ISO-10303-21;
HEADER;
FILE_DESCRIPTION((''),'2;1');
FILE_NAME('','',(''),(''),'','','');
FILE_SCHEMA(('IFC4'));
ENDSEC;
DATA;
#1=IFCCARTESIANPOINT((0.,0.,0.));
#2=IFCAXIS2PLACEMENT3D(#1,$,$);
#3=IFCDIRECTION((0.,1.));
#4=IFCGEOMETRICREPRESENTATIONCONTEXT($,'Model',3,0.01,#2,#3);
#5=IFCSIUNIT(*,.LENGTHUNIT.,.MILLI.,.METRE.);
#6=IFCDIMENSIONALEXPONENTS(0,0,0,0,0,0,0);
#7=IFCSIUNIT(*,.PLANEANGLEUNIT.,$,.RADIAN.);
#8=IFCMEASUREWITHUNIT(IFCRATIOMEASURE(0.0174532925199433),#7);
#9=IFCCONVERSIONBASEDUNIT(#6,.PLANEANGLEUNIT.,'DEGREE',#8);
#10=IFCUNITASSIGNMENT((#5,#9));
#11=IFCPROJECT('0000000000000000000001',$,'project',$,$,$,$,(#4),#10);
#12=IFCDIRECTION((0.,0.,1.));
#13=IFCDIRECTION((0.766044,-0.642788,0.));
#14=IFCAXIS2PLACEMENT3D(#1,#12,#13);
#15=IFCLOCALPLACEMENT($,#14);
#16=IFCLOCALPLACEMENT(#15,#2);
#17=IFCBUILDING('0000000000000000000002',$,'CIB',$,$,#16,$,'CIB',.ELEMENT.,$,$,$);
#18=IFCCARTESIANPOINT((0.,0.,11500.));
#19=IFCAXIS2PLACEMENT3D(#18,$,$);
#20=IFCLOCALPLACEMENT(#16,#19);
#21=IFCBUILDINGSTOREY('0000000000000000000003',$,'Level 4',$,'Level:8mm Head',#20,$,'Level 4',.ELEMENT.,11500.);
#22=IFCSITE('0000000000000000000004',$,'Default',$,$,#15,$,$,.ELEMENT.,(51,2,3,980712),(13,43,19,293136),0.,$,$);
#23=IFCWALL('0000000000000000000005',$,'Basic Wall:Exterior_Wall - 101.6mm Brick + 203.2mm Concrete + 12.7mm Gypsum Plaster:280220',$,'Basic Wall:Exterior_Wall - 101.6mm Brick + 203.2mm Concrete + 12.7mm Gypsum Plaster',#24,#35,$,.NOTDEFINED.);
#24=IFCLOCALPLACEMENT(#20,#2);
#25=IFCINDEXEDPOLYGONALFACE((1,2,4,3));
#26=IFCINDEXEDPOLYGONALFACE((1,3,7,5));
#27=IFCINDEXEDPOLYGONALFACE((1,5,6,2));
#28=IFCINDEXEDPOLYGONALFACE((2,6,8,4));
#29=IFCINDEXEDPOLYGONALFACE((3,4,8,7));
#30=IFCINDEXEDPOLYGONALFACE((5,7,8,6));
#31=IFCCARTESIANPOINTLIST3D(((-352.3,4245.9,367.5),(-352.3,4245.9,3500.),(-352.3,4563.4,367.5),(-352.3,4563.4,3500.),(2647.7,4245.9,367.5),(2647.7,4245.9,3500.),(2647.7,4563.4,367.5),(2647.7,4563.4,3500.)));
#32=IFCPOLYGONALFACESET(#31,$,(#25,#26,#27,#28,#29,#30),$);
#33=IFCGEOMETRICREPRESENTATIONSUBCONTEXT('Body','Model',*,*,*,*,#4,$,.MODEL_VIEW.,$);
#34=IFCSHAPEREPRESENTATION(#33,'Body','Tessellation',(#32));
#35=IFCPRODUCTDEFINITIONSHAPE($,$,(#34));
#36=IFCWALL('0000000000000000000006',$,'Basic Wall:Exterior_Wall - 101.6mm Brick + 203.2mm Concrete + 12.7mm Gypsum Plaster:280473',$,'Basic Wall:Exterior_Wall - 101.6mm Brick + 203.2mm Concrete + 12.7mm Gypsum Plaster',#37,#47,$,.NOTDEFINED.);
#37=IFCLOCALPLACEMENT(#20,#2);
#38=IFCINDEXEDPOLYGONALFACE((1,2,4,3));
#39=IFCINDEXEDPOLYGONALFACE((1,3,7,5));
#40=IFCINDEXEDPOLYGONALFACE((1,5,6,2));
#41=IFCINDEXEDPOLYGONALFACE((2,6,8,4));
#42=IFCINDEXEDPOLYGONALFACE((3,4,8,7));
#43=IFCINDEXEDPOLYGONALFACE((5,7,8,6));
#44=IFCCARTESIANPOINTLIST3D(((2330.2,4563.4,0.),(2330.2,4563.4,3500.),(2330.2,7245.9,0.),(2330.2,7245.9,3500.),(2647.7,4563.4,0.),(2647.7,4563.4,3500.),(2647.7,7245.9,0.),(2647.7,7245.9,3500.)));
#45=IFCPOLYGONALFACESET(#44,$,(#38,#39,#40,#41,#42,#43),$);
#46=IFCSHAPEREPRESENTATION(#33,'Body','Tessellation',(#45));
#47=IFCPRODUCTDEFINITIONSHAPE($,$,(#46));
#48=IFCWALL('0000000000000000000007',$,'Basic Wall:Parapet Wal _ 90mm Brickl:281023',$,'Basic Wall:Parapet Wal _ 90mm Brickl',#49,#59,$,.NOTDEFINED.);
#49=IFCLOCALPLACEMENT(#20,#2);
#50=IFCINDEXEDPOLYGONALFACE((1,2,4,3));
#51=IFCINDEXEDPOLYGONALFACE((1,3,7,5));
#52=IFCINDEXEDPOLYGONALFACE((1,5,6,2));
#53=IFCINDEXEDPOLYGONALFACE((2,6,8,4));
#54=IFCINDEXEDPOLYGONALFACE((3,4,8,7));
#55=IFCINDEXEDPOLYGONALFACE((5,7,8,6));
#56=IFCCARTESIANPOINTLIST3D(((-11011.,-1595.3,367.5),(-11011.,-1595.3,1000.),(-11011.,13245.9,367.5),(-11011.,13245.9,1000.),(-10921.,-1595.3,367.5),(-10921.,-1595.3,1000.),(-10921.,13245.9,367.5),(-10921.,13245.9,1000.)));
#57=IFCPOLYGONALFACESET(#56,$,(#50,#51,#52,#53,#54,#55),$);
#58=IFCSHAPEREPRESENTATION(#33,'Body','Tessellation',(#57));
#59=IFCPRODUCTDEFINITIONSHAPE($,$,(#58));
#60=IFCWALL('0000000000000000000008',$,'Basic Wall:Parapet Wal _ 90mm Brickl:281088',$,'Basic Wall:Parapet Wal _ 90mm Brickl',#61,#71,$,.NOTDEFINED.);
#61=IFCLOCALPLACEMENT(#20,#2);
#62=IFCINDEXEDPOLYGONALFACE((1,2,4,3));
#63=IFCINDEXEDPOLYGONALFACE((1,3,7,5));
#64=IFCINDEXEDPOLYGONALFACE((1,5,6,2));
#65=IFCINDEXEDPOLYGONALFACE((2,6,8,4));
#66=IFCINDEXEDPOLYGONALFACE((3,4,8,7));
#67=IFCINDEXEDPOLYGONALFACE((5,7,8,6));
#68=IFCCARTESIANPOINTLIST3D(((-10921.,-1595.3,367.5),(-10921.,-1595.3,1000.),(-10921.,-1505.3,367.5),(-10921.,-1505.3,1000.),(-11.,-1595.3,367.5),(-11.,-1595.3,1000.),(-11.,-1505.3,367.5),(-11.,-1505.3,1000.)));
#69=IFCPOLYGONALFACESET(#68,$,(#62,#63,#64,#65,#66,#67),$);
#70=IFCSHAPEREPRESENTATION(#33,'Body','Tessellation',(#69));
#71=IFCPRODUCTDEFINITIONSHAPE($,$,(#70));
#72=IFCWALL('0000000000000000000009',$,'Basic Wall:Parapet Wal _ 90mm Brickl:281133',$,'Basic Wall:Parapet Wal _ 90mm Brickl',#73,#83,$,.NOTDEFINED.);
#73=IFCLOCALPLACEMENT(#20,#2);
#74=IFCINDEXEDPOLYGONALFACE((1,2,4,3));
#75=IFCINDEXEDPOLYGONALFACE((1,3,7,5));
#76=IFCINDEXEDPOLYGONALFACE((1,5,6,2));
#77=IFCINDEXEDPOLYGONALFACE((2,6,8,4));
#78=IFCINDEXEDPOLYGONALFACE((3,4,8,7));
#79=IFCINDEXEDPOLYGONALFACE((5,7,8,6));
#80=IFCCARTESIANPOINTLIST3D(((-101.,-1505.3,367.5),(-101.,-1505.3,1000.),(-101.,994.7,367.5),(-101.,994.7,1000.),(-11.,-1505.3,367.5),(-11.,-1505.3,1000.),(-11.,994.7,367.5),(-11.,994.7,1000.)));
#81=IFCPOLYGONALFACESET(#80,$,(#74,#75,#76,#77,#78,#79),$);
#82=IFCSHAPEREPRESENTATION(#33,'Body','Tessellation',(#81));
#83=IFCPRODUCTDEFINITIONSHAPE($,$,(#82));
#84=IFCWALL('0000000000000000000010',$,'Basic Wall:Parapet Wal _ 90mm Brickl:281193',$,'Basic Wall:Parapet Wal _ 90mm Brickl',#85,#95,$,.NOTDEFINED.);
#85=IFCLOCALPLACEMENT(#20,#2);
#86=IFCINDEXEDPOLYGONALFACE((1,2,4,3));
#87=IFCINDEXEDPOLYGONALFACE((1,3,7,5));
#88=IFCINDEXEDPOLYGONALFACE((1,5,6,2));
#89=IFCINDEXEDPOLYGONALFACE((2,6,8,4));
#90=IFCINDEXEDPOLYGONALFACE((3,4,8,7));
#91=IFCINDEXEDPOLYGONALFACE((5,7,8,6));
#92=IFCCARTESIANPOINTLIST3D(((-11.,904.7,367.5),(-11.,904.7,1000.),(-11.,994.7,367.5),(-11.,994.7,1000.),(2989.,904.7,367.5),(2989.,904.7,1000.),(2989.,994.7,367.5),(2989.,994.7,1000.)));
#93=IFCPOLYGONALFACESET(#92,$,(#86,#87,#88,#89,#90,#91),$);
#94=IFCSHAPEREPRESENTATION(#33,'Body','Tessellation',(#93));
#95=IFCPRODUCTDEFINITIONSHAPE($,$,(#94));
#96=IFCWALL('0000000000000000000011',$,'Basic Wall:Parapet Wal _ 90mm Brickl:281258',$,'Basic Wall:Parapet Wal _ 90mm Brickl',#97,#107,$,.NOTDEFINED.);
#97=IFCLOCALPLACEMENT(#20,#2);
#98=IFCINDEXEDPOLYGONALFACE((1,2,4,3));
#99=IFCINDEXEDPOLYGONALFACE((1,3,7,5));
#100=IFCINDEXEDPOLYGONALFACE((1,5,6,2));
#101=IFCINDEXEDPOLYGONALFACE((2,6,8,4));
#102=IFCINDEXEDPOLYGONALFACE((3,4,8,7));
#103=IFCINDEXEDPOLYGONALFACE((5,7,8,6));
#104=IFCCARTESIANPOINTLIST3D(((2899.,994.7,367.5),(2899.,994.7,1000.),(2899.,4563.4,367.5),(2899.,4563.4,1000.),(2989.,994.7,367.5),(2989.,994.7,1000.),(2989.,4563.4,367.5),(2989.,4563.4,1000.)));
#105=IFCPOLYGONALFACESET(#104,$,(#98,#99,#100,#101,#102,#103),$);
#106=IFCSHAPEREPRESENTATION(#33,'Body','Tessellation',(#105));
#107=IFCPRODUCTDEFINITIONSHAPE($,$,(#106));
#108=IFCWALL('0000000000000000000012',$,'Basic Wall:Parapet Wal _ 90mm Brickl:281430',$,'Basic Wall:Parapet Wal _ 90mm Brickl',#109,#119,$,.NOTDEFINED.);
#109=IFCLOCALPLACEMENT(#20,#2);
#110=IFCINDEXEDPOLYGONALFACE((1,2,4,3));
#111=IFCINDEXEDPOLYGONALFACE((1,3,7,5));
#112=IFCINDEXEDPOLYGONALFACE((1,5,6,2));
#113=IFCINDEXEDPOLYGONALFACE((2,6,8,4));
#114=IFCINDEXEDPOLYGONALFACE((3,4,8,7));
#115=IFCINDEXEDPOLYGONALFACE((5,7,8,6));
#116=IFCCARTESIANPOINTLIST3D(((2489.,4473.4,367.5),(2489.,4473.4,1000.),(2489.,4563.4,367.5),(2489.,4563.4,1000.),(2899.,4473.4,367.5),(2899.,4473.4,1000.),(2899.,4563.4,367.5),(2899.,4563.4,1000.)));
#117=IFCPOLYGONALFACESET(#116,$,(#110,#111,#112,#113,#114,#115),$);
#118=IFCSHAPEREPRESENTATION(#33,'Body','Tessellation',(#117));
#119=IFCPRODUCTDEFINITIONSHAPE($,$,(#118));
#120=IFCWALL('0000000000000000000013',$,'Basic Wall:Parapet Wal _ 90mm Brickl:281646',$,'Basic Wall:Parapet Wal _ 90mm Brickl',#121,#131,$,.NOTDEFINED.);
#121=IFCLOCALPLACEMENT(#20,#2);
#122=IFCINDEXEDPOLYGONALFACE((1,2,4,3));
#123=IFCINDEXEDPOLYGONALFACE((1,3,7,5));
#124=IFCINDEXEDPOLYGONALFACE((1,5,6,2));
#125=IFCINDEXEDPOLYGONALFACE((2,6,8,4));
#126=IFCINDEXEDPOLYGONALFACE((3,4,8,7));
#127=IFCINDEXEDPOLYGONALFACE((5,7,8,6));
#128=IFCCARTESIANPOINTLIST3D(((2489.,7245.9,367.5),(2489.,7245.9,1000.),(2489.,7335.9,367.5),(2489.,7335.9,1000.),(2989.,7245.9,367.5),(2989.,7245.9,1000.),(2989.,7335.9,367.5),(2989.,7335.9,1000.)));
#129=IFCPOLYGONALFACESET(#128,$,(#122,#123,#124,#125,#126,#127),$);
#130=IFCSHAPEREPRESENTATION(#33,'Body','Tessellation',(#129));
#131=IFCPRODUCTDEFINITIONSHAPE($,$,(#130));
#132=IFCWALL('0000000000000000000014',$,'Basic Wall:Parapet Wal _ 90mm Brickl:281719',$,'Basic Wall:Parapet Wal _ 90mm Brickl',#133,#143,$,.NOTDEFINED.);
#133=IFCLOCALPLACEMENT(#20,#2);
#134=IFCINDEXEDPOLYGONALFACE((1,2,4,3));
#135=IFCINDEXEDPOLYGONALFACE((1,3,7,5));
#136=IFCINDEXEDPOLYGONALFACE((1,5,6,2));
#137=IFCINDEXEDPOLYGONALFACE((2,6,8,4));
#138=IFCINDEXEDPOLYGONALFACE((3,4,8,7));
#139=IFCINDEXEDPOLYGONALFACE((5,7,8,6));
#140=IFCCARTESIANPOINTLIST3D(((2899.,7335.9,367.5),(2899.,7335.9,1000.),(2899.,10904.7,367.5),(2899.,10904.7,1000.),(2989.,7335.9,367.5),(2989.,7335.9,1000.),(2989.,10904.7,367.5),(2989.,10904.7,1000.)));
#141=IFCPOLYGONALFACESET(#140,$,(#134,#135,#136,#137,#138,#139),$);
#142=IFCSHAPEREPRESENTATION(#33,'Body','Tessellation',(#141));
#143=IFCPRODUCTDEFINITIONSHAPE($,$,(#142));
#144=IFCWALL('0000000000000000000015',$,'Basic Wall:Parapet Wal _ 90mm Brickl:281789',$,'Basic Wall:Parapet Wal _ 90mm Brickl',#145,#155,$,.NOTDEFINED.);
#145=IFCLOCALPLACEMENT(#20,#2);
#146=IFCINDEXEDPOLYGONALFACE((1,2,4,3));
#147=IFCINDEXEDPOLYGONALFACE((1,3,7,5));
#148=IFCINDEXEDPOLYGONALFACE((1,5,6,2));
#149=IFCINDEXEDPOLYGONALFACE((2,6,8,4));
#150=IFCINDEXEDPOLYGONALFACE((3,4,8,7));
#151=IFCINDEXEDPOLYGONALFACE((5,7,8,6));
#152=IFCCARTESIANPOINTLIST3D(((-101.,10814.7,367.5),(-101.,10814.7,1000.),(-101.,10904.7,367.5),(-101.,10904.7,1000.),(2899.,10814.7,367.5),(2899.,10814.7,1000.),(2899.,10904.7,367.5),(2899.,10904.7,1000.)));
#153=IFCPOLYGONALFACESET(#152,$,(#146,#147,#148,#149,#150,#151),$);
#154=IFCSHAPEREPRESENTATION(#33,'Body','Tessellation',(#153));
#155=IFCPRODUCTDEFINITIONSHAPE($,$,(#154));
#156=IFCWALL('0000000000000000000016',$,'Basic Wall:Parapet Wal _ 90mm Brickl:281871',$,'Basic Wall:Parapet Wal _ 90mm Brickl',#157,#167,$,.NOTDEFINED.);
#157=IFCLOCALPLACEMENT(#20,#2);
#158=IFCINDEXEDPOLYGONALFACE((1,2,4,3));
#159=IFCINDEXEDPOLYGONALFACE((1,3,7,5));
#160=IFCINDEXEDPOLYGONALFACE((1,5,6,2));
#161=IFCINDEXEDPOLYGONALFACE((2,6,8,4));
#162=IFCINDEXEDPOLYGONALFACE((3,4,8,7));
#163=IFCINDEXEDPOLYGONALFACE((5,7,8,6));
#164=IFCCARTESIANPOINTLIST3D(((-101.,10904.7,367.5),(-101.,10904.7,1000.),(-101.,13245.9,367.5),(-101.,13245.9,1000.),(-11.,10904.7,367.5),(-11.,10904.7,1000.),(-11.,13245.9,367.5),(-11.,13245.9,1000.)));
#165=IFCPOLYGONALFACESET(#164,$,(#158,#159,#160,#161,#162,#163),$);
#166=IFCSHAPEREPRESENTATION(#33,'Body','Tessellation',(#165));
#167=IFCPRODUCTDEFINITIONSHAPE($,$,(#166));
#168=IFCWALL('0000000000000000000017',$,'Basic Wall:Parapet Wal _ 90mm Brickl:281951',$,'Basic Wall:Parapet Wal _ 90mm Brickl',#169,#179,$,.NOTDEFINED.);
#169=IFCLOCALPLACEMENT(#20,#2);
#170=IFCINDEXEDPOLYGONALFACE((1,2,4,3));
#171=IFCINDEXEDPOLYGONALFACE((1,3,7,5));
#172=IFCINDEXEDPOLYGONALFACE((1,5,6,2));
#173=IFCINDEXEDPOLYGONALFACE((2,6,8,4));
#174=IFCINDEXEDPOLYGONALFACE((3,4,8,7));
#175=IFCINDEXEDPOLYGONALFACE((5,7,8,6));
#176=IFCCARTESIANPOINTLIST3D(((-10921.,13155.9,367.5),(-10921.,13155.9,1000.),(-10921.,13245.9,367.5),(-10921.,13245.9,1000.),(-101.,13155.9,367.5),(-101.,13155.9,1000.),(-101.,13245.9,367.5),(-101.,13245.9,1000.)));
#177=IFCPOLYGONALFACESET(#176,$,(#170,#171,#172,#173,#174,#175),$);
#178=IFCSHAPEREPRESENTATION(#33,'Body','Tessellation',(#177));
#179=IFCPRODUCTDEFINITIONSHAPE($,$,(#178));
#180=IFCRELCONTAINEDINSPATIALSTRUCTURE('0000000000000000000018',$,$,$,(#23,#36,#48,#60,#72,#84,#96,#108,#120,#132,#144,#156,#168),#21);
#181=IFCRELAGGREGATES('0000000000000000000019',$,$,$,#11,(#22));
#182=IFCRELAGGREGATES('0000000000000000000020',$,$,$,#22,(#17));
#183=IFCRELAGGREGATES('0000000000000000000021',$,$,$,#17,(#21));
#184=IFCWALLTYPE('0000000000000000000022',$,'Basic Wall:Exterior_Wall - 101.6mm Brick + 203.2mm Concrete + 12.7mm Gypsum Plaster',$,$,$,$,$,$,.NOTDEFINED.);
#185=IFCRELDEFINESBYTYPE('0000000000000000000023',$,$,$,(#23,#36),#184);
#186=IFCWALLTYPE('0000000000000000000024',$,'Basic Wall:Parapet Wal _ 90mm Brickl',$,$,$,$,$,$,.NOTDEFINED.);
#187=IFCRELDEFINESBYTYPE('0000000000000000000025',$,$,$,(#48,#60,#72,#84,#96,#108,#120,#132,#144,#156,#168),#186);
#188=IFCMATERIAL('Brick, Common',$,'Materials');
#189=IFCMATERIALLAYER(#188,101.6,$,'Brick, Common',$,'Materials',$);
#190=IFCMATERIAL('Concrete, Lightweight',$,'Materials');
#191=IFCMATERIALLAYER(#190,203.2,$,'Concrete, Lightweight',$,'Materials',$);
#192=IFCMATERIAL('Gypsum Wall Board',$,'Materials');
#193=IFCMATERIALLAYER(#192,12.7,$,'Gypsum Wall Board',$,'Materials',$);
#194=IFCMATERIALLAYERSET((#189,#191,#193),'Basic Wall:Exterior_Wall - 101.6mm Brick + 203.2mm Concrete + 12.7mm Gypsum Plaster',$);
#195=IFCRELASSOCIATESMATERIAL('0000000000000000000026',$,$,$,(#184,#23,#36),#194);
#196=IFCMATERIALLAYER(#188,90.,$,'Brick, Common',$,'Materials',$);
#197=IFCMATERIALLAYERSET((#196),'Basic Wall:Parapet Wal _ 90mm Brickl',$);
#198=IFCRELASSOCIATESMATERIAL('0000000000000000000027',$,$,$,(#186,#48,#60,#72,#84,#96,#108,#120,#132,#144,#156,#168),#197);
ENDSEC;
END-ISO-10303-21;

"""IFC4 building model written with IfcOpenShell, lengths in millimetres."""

from ifc_helpers import new_model, entity, si_unit, converted_unit, direction, frame, origin, place, context, subcontext, project, spatial, indexed_curve, outline, extrude, material, layer, layer_set, type_object, element, save


model = new_model("IFC4")

# Units and contexts
model_context = context("Model", 3, precision=0.01, world=origin(), true_north=direction((0.0, 1.0)))
body_context = subcontext(model_context, "Body", "Model", "MODEL_VIEW")
ifc_project = project(units=[si_unit("LENGTHUNIT", "METRE", prefix="MILLI"), converted_unit("PLANEANGLEUNIT", "DEGREE", entity("IfcRatioMeasure", 0.0174532925199433), si_unit("PLANEANGLEUNIT", "RADIAN"), dimensions=[0, 0, 0, 0, 0, 0, 0])], contexts=[model_context])

# Site, building, storey
site_placement = place(None, frame((0.0, 0.0, 0.0), z_axis=(0.0, 0.0, 1.0), x_axis=(0.766044, -0.642788, 0.0)))
site = spatial("IfcSite", under=ifc_project, at=site_placement, Name="Default", CompositionType="ELEMENT", RefLatitude=(51, 2, 3, 980712), RefLongitude=(13, 43, 19, 293136), RefElevation=0.0)
building_placement = place(site_placement, origin())
building = spatial("IfcBuilding", under=site, at=building_placement, Name="CIB", LongName="CIB", CompositionType="ELEMENT")
storey_placement = place(building_placement, frame((0.0, 0.0, 11500.0)))
storey = spatial("IfcBuildingStorey", under=building, at=storey_placement, Name="Level 4", ObjectType="Level:8mm Head", LongName="Level 4", CompositionType="ELEMENT", Elevation=11500.0)

# Walls
ifc_material_1 = material(Name="Brick, Common", Category="Materials")
ifc_layer_1 = layer(ifc_material_1, 101.6, Name="Brick, Common", Category="Materials")
ifc_material_2 = material(Name="Concrete, Lightweight", Category="Materials")
ifc_layer_2 = layer(ifc_material_2, 203.2, Name="Concrete, Lightweight", Category="Materials")
ifc_material_3 = material(Name="Gypsum Wall Board", Category="Materials")
ifc_layer_3 = layer(ifc_material_3, 12.7, Name="Gypsum Wall Board", Category="Materials")
ifc_layer_set_1 = layer_set([ifc_layer_1, ifc_layer_2, ifc_layer_3], Name="Basic Wall:Exterior_Wall - 101.6mm Brick + 203.2mm Concrete + 12.7mm Gypsum Plaster")
wall_type_1 = type_object("IfcWallType", Name="Basic Wall:Exterior_Wall - 101.6mm Brick + 203.2mm Concrete + 12.7mm Gypsum Plaster", PredefinedType="NOTDEFINED", material=ifc_layer_set_1)
wall_1_placement = place(storey_placement, frame((-352.3, 4404.7, 367.5)))
element("IfcWall", 1, at=wall_1_placement, inside=storey, type_object=wall_type_1, material=ifc_layer_set_1, Name="Basic Wall:Exterior_Wall - 101.6mm Brick + 203.2mm Concrete + 12.7mm Gypsum Plaster:280220", ObjectType="Basic Wall:Exterior_Wall - 101.6mm Brick + 203.2mm Concrete + 12.7mm Gypsum Plaster", PredefinedType="NOTDEFINED", context=body_context, shape_type="SweptSolid", body=[
    extrude(outline(indexed_curve([(3000.0, 158.8), (0.0, 158.8), (0.0, -158.8), (3000.0, -158.8), (3000.0, 158.8)], self_intersect=False)), origin(), (0.0, 0.0, 1.0), 3132.5),
])
wall_2_placement = place(storey_placement, frame((2489.0, 7245.9, 0.0), z_axis=(0.0, 0.0, 1.0), x_axis=(0.0, -1.0, 0.0)))
element("IfcWall", 2, at=wall_2_placement, inside=storey, type_object=wall_type_1, material=ifc_layer_set_1, Name="Basic Wall:Exterior_Wall - 101.6mm Brick + 203.2mm Concrete + 12.7mm Gypsum Plaster:280473", ObjectType="Basic Wall:Exterior_Wall - 101.6mm Brick + 203.2mm Concrete + 12.7mm Gypsum Plaster", PredefinedType="NOTDEFINED", context=body_context, shape_type="SweptSolid", body=[
    extrude(outline(indexed_curve([(2682.5, 158.8), (0.0, 158.8), (0.0, -158.8), (2682.5, -158.8), (2682.5, 158.8)], self_intersect=False)), origin(), (0.0, 0.0, 1.0), 3500.0),
])
ifc_layer_4 = layer(ifc_material_1, 90.0, Name="Brick, Common", Category="Materials")
ifc_layer_set_2 = layer_set([ifc_layer_4], Name="Basic Wall:Parapet Wal _ 90mm Brickl")
wall_type_2 = type_object("IfcWallType", Name="Basic Wall:Parapet Wal _ 90mm Brickl", PredefinedType="NOTDEFINED", material=ifc_layer_set_2)
wall_3_placement = place(storey_placement, frame((-10966.0, 13245.9, 367.5), z_axis=(0.0, 0.0, 1.0), x_axis=(0.0, -1.0, 0.0)))
element("IfcWall", 3, at=wall_3_placement, inside=storey, type_object=wall_type_2, material=ifc_layer_set_2, Name="Basic Wall:Parapet Wal _ 90mm Brickl:281023", ObjectType="Basic Wall:Parapet Wal _ 90mm Brickl", PredefinedType="NOTDEFINED", context=body_context, shape_type="SweptSolid", body=[
    extrude(outline(indexed_curve([(14841.2, 45.0), (0.0, 45.0), (0.0, -45.0), (14841.2, -45.0), (14841.2, 45.0)], self_intersect=False)), origin(), (0.0, 0.0, 1.0), 632.5),
])
wall_4_placement = place(storey_placement, frame((-10921.0, -1550.3, 367.5)))
element("IfcWall", 4, at=wall_4_placement, inside=storey, type_object=wall_type_2, material=ifc_layer_set_2, Name="Basic Wall:Parapet Wal _ 90mm Brickl:281088", ObjectType="Basic Wall:Parapet Wal _ 90mm Brickl", PredefinedType="NOTDEFINED", context=body_context, shape_type="SweptSolid", body=[
    extrude(outline(indexed_curve([(10910.0, 45.0), (0.0, 45.0), (0.0, -45.0), (10910.0, -45.0), (10910.0, 45.0)], self_intersect=False)), origin(), (0.0, 0.0, 1.0), 632.5),
])
wall_5_placement = place(storey_placement, frame((-56.0, -1505.3, 367.5), z_axis=(0.0, 0.0, 1.0), x_axis=(0.0, 1.0, 0.0)))
element("IfcWall", 5, at=wall_5_placement, inside=storey, type_object=wall_type_2, material=ifc_layer_set_2, Name="Basic Wall:Parapet Wal _ 90mm Brickl:281133", ObjectType="Basic Wall:Parapet Wal _ 90mm Brickl", PredefinedType="NOTDEFINED", context=body_context, shape_type="SweptSolid", body=[
    extrude(outline(indexed_curve([(2500.0, 45.0), (0.0, 45.0), (0.0, -45.0), (2500.0, -45.0), (2500.0, 45.0)], self_intersect=False)), origin(), (0.0, 0.0, 1.0), 632.5),
])
wall_6_placement = place(storey_placement, frame((-11.0, 949.7, 367.5)))
element("IfcWall", 6, at=wall_6_placement, inside=storey, type_object=wall_type_2, material=ifc_layer_set_2, Name="Basic Wall:Parapet Wal _ 90mm Brickl:281193", ObjectType="Basic Wall:Parapet Wal _ 90mm Brickl", PredefinedType="NOTDEFINED", context=body_context, shape_type="SweptSolid", body=[
    extrude(outline(indexed_curve([(3000.0, 45.0), (0.0, 45.0), (0.0, -45.0), (3000.0, -45.0), (3000.0, 45.0)], self_intersect=False)), origin(), (0.0, 0.0, 1.0), 632.5),
])
wall_7_placement = place(storey_placement, frame((2944.0, 994.7, 367.5), z_axis=(0.0, 0.0, 1.0), x_axis=(0.0, 1.0, 0.0)))
element("IfcWall", 7, at=wall_7_placement, inside=storey, type_object=wall_type_2, material=ifc_layer_set_2, Name="Basic Wall:Parapet Wal _ 90mm Brickl:281258", ObjectType="Basic Wall:Parapet Wal _ 90mm Brickl", PredefinedType="NOTDEFINED", context=body_context, shape_type="SweptSolid", body=[
    extrude(outline(indexed_curve([(3568.8, 45.0), (0.0, 45.0), (0.0, -45.0), (3568.8, -45.0), (3568.8, 45.0)], self_intersect=False)), origin(), (0.0, 0.0, 1.0), 632.5),
])
wall_8_placement = place(storey_placement, frame((2899.0, 4518.4, 367.5), z_axis=(0.0, 0.0, 1.0), x_axis=(-1.0, 0.0, 0.0)))
element("IfcWall", 8, at=wall_8_placement, inside=storey, type_object=wall_type_2, material=ifc_layer_set_2, Name="Basic Wall:Parapet Wal _ 90mm Brickl:281430", ObjectType="Basic Wall:Parapet Wal _ 90mm Brickl", PredefinedType="NOTDEFINED", context=body_context, shape_type="SweptSolid", body=[
    extrude(outline(indexed_curve([(410.0, 45.0), (0.0, 45.0), (0.0, -45.0), (410.0, -45.0), (410.0, 45.0)], self_intersect=False)), origin(), (0.0, 0.0, 1.0), 632.5),
])
wall_9_placement = place(storey_placement, frame((2489.0, 7290.9, 367.5)))
element("IfcWall", 9, at=wall_9_placement, inside=storey, type_object=wall_type_2, material=ifc_layer_set_2, Name="Basic Wall:Parapet Wal _ 90mm Brickl:281646", ObjectType="Basic Wall:Parapet Wal _ 90mm Brickl", PredefinedType="NOTDEFINED", context=body_context, shape_type="SweptSolid", body=[
    extrude(outline(indexed_curve([(500.0, 45.0), (0.0, 45.0), (0.0, -45.0), (500.0, -45.0), (500.0, 45.0)], self_intersect=False)), origin(), (0.0, 0.0, 1.0), 632.5),
])
wall_10_placement = place(storey_placement, frame((2944.0, 7335.9, 367.5), z_axis=(0.0, 0.0, 1.0), x_axis=(0.0, 1.0, 0.0)))
element("IfcWall", 10, at=wall_10_placement, inside=storey, type_object=wall_type_2, material=ifc_layer_set_2, Name="Basic Wall:Parapet Wal _ 90mm Brickl:281719", ObjectType="Basic Wall:Parapet Wal _ 90mm Brickl", PredefinedType="NOTDEFINED", context=body_context, shape_type="SweptSolid", body=[
    extrude(outline(indexed_curve([(3568.7, 45.0), (0.0, 45.0), (0.0, -45.0), (3568.7, -45.0), (3568.7, 45.0)], self_intersect=False)), origin(), (0.0, 0.0, 1.0), 632.5),
])
wall_11_placement = place(storey_placement, frame((2899.0, 10859.7, 367.5), z_axis=(0.0, 0.0, 1.0), x_axis=(-1.0, 0.0, 0.0)))
element("IfcWall", 11, at=wall_11_placement, inside=storey, type_object=wall_type_2, material=ifc_layer_set_2, Name="Basic Wall:Parapet Wal _ 90mm Brickl:281789", ObjectType="Basic Wall:Parapet Wal _ 90mm Brickl", PredefinedType="NOTDEFINED", context=body_context, shape_type="SweptSolid", body=[
    extrude(outline(indexed_curve([(3000.0, 45.0), (0.0, 45.0), (0.0, -45.0), (3000.0, -45.0), (3000.0, 45.0)], self_intersect=False)), origin(), (0.0, 0.0, 1.0), 632.5),
])
wall_12_placement = place(storey_placement, frame((-56.0, 10904.7, 367.5), z_axis=(0.0, 0.0, 1.0), x_axis=(0.0, 1.0, 0.0)))
element("IfcWall", 12, at=wall_12_placement, inside=storey, type_object=wall_type_2, material=ifc_layer_set_2, Name="Basic Wall:Parapet Wal _ 90mm Brickl:281871", ObjectType="Basic Wall:Parapet Wal _ 90mm Brickl", PredefinedType="NOTDEFINED", context=body_context, shape_type="SweptSolid", body=[
    extrude(outline(indexed_curve([(2341.3, 45.0), (0.0, 45.0), (0.0, -45.0), (2341.3, -45.0), (2341.3, 45.0)], self_intersect=False)), origin(), (0.0, 0.0, 1.0), 632.5),
])
wall_13_placement = place(storey_placement, frame((-101.0, 13200.9, 367.5), z_axis=(0.0, 0.0, 1.0), x_axis=(-1.0, 0.0, 0.0)))
element("IfcWall", 13, at=wall_13_placement, inside=storey, type_object=wall_type_2, material=ifc_layer_set_2, Name="Basic Wall:Parapet Wal _ 90mm Brickl:281951", ObjectType="Basic Wall:Parapet Wal _ 90mm Brickl", PredefinedType="NOTDEFINED", context=body_context, shape_type="SweptSolid", body=[
    extrude(outline(indexed_curve([(10820.0, 45.0), (0.0, 45.0), (0.0, -45.0), (10820.0, -45.0), (10820.0, 45.0)], self_intersect=False)), origin(), (0.0, 0.0, 1.0), 632.5),
])

save(model, "model.ifc")
